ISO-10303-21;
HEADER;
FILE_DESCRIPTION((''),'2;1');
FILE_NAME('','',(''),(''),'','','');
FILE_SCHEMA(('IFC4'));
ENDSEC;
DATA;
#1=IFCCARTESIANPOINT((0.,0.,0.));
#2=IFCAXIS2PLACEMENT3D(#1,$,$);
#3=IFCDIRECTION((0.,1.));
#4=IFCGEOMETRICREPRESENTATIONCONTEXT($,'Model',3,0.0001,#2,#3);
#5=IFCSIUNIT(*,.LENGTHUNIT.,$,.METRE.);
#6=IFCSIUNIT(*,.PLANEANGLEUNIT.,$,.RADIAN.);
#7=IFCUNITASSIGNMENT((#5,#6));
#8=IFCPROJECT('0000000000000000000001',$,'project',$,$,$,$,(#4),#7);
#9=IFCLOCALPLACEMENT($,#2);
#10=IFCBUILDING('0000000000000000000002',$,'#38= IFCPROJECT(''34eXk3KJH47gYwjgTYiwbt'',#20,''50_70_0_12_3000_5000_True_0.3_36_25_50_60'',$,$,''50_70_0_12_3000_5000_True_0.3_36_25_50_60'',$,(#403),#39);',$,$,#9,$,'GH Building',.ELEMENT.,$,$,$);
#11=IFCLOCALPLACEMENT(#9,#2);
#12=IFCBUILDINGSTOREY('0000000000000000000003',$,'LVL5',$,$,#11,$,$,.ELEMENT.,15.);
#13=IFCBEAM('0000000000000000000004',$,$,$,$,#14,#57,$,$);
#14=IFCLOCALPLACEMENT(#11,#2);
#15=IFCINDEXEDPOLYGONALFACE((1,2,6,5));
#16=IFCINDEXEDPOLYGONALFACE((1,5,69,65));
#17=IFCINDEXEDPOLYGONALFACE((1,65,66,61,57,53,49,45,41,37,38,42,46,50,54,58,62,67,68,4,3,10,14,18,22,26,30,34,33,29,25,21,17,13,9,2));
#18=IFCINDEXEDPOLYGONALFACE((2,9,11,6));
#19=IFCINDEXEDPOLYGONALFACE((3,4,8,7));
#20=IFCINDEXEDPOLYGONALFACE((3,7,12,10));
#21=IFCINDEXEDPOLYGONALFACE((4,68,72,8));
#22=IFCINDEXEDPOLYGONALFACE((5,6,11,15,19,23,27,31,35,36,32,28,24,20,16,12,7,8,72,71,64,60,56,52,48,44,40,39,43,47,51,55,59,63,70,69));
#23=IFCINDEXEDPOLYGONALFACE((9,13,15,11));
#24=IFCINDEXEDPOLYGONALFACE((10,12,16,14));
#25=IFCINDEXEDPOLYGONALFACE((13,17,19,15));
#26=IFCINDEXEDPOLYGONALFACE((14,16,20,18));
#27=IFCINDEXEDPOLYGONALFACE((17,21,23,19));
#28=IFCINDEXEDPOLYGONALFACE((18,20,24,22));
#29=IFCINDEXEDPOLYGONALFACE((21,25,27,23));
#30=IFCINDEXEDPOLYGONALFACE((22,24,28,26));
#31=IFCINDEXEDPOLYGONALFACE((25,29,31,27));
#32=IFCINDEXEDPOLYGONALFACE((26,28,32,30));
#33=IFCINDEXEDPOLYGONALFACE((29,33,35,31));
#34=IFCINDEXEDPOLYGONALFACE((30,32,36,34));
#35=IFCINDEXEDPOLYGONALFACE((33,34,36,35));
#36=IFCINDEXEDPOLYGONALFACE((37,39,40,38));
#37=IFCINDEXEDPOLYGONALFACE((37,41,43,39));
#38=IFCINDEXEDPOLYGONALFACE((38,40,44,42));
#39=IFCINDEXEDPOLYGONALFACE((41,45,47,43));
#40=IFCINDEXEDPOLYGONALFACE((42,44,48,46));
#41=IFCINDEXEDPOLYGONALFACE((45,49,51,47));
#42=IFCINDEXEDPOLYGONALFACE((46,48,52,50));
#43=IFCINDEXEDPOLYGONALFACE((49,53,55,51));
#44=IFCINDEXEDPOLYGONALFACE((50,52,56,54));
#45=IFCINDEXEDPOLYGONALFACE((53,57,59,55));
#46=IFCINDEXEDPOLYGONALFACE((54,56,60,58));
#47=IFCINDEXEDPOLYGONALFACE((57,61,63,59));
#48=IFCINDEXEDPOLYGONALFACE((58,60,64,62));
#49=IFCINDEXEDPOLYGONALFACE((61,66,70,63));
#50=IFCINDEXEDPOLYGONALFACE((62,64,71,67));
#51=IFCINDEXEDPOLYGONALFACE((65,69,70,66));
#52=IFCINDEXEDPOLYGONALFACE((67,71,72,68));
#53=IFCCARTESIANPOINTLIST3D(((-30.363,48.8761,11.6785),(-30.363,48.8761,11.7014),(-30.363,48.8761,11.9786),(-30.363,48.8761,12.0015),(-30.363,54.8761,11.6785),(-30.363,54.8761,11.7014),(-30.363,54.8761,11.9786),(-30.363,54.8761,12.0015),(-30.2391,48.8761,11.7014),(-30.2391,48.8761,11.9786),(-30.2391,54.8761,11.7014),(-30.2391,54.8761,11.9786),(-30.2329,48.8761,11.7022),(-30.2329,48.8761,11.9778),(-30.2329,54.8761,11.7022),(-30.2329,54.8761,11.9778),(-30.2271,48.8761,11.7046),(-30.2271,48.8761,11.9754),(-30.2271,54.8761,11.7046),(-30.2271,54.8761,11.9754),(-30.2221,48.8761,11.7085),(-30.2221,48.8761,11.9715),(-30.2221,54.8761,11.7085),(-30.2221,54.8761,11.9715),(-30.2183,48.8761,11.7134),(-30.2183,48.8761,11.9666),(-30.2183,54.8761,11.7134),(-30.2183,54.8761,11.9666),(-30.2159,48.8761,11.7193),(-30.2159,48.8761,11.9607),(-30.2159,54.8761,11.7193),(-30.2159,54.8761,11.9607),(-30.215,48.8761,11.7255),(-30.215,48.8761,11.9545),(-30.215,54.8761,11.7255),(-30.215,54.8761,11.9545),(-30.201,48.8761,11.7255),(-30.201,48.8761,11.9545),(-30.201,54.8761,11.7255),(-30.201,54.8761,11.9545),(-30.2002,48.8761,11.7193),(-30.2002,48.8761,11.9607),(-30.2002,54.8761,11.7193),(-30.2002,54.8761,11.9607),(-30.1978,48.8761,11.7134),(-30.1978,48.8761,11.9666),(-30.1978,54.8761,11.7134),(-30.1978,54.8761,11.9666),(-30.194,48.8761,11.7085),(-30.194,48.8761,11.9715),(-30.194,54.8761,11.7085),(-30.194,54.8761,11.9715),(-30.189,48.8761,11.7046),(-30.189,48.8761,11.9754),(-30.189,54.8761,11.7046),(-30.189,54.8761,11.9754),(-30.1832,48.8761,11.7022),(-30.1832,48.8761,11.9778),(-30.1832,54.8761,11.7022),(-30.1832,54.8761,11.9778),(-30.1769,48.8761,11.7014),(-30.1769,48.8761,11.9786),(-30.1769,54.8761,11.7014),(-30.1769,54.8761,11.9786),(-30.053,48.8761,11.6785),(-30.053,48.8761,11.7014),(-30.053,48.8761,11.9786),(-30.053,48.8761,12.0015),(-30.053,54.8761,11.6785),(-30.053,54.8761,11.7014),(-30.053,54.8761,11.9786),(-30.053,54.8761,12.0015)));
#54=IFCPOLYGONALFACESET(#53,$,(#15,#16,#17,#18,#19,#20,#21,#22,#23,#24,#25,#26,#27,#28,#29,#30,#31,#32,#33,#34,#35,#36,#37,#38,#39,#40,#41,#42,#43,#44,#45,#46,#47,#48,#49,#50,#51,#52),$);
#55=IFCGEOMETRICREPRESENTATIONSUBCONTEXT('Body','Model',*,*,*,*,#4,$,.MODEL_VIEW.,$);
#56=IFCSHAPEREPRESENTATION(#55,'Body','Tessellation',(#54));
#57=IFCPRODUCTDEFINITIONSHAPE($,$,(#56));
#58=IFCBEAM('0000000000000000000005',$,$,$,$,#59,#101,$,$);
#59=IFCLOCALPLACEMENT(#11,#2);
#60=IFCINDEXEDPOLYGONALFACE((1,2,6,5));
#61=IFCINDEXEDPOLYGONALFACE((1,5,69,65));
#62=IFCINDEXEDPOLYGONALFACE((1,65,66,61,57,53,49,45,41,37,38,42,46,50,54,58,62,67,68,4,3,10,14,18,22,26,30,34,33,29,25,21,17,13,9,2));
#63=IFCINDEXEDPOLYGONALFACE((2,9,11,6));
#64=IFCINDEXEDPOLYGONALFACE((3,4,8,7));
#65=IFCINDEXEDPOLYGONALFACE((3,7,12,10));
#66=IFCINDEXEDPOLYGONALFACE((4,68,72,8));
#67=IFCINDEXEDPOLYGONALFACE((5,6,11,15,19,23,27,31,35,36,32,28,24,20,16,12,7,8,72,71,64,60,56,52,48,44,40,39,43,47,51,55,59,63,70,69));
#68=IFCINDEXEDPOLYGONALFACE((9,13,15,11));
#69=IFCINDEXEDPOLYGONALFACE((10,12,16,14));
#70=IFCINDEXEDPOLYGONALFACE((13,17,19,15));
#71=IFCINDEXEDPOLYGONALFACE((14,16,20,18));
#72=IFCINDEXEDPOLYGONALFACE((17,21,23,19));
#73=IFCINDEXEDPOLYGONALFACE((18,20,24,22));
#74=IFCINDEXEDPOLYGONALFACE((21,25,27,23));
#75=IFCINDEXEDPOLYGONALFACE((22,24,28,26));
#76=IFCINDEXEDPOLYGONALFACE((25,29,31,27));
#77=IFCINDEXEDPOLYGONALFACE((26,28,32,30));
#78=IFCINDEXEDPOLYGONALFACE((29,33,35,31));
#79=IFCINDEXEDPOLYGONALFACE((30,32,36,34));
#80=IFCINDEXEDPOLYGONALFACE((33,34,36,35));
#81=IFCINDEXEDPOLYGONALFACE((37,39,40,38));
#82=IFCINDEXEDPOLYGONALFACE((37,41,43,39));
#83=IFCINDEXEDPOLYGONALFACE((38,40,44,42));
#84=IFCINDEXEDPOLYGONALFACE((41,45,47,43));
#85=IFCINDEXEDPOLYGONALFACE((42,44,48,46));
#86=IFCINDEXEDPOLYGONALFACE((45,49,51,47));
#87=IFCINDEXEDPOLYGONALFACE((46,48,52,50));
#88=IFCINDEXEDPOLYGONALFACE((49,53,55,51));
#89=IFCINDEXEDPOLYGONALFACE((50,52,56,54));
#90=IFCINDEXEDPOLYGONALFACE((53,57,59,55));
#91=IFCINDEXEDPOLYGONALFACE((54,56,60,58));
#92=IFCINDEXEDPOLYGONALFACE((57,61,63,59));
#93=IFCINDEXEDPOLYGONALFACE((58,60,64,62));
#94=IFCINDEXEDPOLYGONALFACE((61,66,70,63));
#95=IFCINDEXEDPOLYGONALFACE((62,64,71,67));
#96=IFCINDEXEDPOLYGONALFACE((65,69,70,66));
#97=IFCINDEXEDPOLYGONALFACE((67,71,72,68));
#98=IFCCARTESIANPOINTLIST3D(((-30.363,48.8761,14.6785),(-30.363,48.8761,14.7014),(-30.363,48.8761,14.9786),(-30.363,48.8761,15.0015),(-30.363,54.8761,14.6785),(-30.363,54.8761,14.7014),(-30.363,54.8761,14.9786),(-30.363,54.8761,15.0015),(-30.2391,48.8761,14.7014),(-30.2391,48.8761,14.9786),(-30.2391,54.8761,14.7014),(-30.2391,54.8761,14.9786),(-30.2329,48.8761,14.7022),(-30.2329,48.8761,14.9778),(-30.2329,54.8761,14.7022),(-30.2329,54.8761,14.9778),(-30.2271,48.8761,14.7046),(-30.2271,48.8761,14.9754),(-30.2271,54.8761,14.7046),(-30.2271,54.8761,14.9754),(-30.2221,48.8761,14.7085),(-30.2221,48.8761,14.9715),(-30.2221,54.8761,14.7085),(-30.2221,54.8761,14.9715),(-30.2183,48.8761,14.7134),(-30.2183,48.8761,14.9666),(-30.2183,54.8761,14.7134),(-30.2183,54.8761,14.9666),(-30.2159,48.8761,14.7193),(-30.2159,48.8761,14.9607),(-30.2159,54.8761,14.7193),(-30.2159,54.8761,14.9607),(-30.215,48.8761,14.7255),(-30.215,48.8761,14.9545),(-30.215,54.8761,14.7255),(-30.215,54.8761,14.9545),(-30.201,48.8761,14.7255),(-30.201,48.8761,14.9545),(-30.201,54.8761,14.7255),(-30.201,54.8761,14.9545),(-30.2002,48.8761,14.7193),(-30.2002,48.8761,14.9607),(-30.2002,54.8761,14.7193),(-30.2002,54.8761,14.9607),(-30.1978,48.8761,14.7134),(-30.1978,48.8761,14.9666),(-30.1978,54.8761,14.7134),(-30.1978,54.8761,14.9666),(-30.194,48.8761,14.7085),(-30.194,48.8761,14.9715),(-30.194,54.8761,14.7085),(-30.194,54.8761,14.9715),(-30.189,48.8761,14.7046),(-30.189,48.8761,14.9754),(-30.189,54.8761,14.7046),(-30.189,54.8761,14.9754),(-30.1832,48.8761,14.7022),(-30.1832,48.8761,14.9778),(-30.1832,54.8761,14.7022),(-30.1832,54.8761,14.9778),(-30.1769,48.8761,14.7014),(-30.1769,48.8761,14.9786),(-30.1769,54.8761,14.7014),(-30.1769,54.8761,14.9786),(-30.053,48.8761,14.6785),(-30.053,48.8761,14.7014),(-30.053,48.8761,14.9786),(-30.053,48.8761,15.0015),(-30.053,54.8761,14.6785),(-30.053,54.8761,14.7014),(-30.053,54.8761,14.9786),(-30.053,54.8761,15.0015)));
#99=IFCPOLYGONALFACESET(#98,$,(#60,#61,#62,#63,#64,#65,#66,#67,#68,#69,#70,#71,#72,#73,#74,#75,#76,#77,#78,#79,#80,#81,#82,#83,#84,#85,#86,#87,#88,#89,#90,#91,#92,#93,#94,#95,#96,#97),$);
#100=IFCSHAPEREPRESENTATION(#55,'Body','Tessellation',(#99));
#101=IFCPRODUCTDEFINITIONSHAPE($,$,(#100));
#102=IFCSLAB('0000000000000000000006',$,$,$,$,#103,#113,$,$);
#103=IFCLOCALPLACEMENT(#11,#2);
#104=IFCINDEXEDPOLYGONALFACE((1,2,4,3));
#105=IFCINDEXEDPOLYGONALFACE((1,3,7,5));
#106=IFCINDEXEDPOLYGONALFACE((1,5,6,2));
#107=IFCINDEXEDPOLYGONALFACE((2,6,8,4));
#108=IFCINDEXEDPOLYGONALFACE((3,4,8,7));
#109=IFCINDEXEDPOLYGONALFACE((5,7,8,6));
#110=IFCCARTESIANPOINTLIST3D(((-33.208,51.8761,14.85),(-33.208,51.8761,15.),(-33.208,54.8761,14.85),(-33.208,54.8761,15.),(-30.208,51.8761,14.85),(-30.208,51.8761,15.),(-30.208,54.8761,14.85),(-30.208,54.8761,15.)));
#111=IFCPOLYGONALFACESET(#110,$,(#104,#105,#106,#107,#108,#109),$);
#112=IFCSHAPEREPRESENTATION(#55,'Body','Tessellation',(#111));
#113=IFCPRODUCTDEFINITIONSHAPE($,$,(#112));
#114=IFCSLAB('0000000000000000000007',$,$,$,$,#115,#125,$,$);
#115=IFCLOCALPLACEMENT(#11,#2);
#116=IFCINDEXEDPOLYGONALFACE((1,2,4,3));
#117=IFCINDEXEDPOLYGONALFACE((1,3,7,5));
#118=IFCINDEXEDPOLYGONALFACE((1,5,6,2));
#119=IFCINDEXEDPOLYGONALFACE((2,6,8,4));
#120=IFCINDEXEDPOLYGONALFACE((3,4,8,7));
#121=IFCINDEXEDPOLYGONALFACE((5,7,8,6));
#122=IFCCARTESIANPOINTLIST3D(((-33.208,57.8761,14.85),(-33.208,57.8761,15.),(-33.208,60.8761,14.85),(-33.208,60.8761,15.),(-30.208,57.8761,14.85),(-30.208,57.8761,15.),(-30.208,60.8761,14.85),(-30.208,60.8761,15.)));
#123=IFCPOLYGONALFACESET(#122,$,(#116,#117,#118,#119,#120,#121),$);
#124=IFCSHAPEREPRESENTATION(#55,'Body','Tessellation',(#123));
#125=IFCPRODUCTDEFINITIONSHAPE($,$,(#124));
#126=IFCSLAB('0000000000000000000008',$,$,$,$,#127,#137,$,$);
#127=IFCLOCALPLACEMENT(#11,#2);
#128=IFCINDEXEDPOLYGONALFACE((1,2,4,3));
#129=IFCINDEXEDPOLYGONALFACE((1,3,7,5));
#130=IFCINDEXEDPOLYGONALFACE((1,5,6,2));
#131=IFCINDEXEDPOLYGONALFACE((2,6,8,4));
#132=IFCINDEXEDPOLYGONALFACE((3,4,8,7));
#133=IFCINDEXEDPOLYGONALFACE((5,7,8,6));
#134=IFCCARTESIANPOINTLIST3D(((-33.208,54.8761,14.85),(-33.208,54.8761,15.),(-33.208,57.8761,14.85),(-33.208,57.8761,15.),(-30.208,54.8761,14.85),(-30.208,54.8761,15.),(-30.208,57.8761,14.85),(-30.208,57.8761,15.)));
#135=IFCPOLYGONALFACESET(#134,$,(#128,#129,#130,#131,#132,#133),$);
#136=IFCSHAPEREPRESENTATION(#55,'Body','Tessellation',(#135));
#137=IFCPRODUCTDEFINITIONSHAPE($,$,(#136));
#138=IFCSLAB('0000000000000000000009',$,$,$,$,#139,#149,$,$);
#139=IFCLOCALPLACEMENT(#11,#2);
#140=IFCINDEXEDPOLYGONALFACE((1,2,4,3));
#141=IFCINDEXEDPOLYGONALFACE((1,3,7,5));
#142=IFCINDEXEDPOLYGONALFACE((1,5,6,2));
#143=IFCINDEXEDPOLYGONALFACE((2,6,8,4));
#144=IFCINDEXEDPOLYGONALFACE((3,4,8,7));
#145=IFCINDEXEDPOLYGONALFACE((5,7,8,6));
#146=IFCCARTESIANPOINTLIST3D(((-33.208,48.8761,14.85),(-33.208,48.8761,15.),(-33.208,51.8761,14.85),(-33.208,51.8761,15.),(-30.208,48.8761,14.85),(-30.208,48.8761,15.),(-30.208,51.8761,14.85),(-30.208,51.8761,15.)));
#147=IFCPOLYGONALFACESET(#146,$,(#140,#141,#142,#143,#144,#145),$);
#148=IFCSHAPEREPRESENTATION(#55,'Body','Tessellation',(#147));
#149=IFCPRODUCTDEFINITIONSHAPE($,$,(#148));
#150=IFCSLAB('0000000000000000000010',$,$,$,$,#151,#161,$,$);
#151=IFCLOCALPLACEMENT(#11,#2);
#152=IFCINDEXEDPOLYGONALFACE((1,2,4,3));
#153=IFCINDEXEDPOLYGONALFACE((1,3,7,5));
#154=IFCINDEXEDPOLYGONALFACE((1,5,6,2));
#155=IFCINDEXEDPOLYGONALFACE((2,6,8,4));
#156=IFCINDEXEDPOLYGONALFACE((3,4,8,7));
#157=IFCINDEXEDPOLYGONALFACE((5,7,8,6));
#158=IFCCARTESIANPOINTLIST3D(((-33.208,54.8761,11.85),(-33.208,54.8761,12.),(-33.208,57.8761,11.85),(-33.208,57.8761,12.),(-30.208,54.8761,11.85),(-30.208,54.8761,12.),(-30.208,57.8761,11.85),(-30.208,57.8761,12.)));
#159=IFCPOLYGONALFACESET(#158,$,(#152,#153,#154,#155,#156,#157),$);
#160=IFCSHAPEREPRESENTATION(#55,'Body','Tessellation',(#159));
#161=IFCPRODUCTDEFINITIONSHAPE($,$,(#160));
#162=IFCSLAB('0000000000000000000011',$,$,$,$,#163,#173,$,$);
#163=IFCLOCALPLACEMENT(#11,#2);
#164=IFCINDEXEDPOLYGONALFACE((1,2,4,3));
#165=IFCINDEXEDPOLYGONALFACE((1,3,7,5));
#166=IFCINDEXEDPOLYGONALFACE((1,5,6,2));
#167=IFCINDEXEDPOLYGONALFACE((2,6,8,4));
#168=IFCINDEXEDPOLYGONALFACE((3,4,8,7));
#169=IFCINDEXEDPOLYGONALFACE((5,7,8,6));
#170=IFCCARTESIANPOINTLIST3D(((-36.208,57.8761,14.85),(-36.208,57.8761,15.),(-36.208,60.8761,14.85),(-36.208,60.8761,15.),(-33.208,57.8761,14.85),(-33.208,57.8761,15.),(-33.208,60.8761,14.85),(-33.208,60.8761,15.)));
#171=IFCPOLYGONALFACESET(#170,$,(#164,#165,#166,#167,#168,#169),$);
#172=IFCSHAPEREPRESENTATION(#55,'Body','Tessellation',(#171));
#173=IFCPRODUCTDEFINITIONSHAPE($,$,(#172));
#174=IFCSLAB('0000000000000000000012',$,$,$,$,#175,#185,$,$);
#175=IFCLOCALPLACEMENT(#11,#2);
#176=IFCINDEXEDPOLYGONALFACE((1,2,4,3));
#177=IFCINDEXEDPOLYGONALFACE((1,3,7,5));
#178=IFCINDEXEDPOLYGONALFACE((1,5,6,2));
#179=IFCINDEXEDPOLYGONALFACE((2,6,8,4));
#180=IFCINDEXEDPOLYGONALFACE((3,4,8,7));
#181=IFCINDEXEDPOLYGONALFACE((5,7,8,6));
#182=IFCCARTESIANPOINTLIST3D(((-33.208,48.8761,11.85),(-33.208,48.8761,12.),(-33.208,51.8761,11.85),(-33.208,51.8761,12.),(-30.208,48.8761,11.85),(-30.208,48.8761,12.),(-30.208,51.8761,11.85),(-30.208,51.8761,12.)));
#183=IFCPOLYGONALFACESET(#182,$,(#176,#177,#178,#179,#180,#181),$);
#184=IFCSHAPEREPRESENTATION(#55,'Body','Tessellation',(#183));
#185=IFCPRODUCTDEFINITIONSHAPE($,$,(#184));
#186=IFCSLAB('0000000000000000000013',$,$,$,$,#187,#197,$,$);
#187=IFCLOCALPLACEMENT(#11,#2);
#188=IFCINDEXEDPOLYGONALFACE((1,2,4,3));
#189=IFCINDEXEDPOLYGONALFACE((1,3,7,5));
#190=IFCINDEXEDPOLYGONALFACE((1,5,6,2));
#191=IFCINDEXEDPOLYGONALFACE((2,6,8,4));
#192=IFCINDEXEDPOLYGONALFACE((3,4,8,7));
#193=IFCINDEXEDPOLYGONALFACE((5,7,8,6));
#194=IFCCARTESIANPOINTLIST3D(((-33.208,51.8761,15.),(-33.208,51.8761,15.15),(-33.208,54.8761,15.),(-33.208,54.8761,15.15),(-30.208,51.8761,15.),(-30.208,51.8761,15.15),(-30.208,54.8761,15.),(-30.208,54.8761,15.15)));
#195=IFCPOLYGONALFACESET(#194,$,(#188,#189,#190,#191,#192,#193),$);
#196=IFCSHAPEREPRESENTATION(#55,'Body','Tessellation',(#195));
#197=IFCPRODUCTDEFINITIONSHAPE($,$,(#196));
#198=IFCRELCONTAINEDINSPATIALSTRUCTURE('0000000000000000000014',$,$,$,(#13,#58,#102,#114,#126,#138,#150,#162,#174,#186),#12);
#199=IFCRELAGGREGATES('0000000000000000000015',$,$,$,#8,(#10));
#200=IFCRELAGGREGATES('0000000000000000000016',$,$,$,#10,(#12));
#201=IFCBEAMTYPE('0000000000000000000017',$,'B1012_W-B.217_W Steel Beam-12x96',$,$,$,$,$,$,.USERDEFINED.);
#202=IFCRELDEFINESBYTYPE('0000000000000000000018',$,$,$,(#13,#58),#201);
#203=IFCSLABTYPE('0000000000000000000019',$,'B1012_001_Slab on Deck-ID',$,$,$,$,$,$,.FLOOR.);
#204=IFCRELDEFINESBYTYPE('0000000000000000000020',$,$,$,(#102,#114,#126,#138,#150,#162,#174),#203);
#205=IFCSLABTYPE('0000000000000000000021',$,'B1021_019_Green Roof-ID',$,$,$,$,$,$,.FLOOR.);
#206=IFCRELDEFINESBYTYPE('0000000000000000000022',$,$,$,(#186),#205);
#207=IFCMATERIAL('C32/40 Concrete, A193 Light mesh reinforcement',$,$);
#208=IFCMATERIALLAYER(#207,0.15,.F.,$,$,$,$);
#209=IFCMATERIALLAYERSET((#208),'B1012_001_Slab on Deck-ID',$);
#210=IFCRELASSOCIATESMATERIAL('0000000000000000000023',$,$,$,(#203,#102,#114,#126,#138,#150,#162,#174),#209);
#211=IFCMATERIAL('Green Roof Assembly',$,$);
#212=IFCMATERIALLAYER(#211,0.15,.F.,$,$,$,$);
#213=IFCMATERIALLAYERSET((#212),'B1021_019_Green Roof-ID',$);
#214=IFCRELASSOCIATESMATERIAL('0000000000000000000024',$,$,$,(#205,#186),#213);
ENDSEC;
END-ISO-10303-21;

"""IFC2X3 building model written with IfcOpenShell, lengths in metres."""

from ifc_helpers import new_model, si_unit, direction, frame, origin, origin_2d, place, context, subcontext, project, spatial, polyline, i_section, outline, extrude, material, layer, layer_set, layer_usage, type_object, element, save


model = new_model("IFC2X3")

# Units and contexts
model_context = context("Model", 3, precision=0.0001, world=origin(), true_north=direction((0.0, 1.0)))
body_context = subcontext(model_context, "Body", "Model", "MODEL_VIEW")
ifc_project = project(units=[si_unit("LENGTHUNIT", "METRE"), si_unit("PLANEANGLEUNIT", "RADIAN")], contexts=[model_context])

# Building, storey
building_placement = place(None, origin())
building = spatial("IfcBuilding", under=ifc_project, at=building_placement, Name="#38= IFCPROJECT('34eXk3KJH47gYwjgTYiwbt',#20,'50_70_0_12_3000_5000_True_0.3_36_25_50_60',$,$,'50_70_0_12_3000_5000_True_0.3_36_25_50_60',$,(#403),#39);", LongName="GH Building", CompositionType="ELEMENT")
storey_placement = place(building_placement, origin())
storey = spatial("IfcBuildingStorey", under=building, at=storey_placement, Name="LVL5", CompositionType="ELEMENT", Elevation=15.0)

# Beams
beam_type = type_object("IfcBeamType", Name="B1012_W-B.217_W Steel Beam-12x96", PredefinedType="USERDEFINED")
for number, where, z_axis, x_axis in (
    (1, (-30.208, 48.8761, 11.84), (0.0, 1.0, 0.0), (-1.0, 0.0, 0.0)),
    (2, (-30.208, 48.8761, 14.84), (0.0, 1.0, 0.0), (-1.0, 0.0, 0.0)),
):
    element("IfcBeam", number, at=place(storey_placement, frame(where, z_axis=z_axis, x_axis=x_axis)), inside=storey, type_object=beam_type, context=body_context, shape_type="SweptSolid", body=[
        extrude(i_section(OverallWidth=0.31, OverallDepth=0.323, WebThickness=0.014, FlangeThickness=0.0229, FilletRadius=0.0241, at=origin_2d()), origin(), (0.0, 0.0, 1.0), 6.0),
    ])

# Slabs
ifc_material_1 = material(Name="C32/40 Concrete, A193 Light mesh reinforcement")
ifc_layer_1 = layer(ifc_material_1, 0.15, ventilated=False)
ifc_layer_set_1 = layer_set([ifc_layer_1], Name="B1012_001_Slab on Deck-ID")
ifc_layer_usage_1 = layer_usage(ifc_layer_set_1, "AXIS3", "NEGATIVE", -0.15)
slab_type_1 = type_object("IfcSlabType", Name="B1012_001_Slab on Deck-ID", PredefinedType="FLOOR", material=ifc_layer_set_1)
slab_1_placement = place(storey_placement, frame((-31.708, 53.3761, 14.85)))
element("IfcSlab", 3, at=slab_1_placement, inside=storey, type_object=slab_type_1, material=ifc_layer_usage_1, context=body_context, shape_type="SweptSolid", body=[
    extrude(outline(polyline([(1.5, -1.5), (-1.5, -1.5), (-1.5, 1.5), (1.5, 1.5), (1.5, -1.5)])), origin(), (0.0, 0.0, 1.0), 0.15),
])
ifc_layer_usage_2 = layer_usage(ifc_layer_set_1, "AXIS3", "NEGATIVE", -0.15)
slab_2_placement = place(storey_placement, frame((-31.708, 59.3761, 14.85)))
element("IfcSlab", 4, at=slab_2_placement, inside=storey, type_object=slab_type_1, material=ifc_layer_usage_2, context=body_context, shape_type="SweptSolid", body=[
    extrude(outline(polyline([(-1.5, 1.5), (1.5, 1.5), (1.5, -1.5), (-1.5, -1.5), (-1.5, 1.5)])), origin(), (0.0, 0.0, 1.0), 0.15),
])
ifc_layer_usage_3 = layer_usage(ifc_layer_set_1, "AXIS3", "NEGATIVE", -0.15)
slab_3_placement = place(storey_placement, frame((-31.708, 56.3761, 14.85)))
element("IfcSlab", 5, at=slab_3_placement, inside=storey, type_object=slab_type_1, material=ifc_layer_usage_3, context=body_context, shape_type="SweptSolid", body=[
    extrude(outline(polyline([(1.5, -1.5), (-1.5, -1.5), (-1.5, 1.5), (1.5, 1.5), (1.5, -1.5)])), origin(), (0.0, 0.0, 1.0), 0.15),
])
ifc_layer_usage_4 = layer_usage(ifc_layer_set_1, "AXIS3", "NEGATIVE", -0.15)
slab_4_placement = place(storey_placement, frame((-31.708, 50.3761, 14.85)))
element("IfcSlab", 6, at=slab_4_placement, inside=storey, type_object=slab_type_1, material=ifc_layer_usage_4, context=body_context, shape_type="SweptSolid", body=[
    extrude(outline(polyline([(-1.5, 1.5), (1.5, 1.5), (1.5, -1.5), (-1.5, -1.5), (-1.5, 1.5)])), origin(), (0.0, 0.0, 1.0), 0.15),
])
ifc_layer_usage_5 = layer_usage(ifc_layer_set_1, "AXIS3", "NEGATIVE", -0.15)
slab_5_placement = place(storey_placement, frame((-31.708, 56.3761, 11.85)))
element("IfcSlab", 7, at=slab_5_placement, inside=storey, type_object=slab_type_1, material=ifc_layer_usage_5, context=body_context, shape_type="SweptSolid", body=[
    extrude(outline(polyline([(1.5, -1.5), (-1.5, -1.5), (-1.5, 1.5), (1.5, 1.5), (1.5, -1.5)])), origin(), (0.0, 0.0, 1.0), 0.15),
])
ifc_layer_usage_6 = layer_usage(ifc_layer_set_1, "AXIS3", "NEGATIVE", -0.15)
slab_6_placement = place(storey_placement, frame((-34.708, 59.3761, 14.85)))
element("IfcSlab", 8, at=slab_6_placement, inside=storey, type_object=slab_type_1, material=ifc_layer_usage_6, context=body_context, shape_type="SweptSolid", body=[
    extrude(outline(polyline([(-1.5, 1.5), (1.5, 1.5), (1.5, -1.5), (-1.5, -1.5), (-1.5, 1.5)])), origin(), (0.0, 0.0, 1.0), 0.15),
])
ifc_layer_usage_7 = layer_usage(ifc_layer_set_1, "AXIS3", "NEGATIVE", -0.15)
slab_7_placement = place(storey_placement, frame((-31.708, 50.3761, 11.85)))
element("IfcSlab", 9, at=slab_7_placement, inside=storey, type_object=slab_type_1, material=ifc_layer_usage_7, context=body_context, shape_type="SweptSolid", body=[
    extrude(outline(polyline([(1.5, -1.5), (-1.5, -1.5), (-1.5, 1.5), (1.5, 1.5), (1.5, -1.5)])), origin(), (0.0, 0.0, 1.0), 0.15),
])
ifc_material_2 = material(Name="Green Roof Assembly")
ifc_layer_2 = layer(ifc_material_2, 0.15, ventilated=False)
ifc_layer_set_2 = layer_set([ifc_layer_2], Name="B1021_019_Green Roof-ID")
ifc_layer_usage_8 = layer_usage(ifc_layer_set_2, "AXIS3", "NEGATIVE", -0.15)
slab_type_2 = type_object("IfcSlabType", Name="B1021_019_Green Roof-ID", PredefinedType="FLOOR", material=ifc_layer_set_2)
slab_8_placement = place(storey_placement, frame((-31.708, 53.3761, 15.0)))
element("IfcSlab", 10, at=slab_8_placement, inside=storey, type_object=slab_type_2, material=ifc_layer_usage_8, context=body_context, shape_type="SweptSolid", body=[
    extrude(outline(polyline([(1.5, -1.5), (-1.5, -1.5), (-1.5, 1.5), (1.5, 1.5), (1.5, -1.5)])), origin(), (0.0, 0.0, 1.0), 0.15),
])

save(model, "model.ifc")
